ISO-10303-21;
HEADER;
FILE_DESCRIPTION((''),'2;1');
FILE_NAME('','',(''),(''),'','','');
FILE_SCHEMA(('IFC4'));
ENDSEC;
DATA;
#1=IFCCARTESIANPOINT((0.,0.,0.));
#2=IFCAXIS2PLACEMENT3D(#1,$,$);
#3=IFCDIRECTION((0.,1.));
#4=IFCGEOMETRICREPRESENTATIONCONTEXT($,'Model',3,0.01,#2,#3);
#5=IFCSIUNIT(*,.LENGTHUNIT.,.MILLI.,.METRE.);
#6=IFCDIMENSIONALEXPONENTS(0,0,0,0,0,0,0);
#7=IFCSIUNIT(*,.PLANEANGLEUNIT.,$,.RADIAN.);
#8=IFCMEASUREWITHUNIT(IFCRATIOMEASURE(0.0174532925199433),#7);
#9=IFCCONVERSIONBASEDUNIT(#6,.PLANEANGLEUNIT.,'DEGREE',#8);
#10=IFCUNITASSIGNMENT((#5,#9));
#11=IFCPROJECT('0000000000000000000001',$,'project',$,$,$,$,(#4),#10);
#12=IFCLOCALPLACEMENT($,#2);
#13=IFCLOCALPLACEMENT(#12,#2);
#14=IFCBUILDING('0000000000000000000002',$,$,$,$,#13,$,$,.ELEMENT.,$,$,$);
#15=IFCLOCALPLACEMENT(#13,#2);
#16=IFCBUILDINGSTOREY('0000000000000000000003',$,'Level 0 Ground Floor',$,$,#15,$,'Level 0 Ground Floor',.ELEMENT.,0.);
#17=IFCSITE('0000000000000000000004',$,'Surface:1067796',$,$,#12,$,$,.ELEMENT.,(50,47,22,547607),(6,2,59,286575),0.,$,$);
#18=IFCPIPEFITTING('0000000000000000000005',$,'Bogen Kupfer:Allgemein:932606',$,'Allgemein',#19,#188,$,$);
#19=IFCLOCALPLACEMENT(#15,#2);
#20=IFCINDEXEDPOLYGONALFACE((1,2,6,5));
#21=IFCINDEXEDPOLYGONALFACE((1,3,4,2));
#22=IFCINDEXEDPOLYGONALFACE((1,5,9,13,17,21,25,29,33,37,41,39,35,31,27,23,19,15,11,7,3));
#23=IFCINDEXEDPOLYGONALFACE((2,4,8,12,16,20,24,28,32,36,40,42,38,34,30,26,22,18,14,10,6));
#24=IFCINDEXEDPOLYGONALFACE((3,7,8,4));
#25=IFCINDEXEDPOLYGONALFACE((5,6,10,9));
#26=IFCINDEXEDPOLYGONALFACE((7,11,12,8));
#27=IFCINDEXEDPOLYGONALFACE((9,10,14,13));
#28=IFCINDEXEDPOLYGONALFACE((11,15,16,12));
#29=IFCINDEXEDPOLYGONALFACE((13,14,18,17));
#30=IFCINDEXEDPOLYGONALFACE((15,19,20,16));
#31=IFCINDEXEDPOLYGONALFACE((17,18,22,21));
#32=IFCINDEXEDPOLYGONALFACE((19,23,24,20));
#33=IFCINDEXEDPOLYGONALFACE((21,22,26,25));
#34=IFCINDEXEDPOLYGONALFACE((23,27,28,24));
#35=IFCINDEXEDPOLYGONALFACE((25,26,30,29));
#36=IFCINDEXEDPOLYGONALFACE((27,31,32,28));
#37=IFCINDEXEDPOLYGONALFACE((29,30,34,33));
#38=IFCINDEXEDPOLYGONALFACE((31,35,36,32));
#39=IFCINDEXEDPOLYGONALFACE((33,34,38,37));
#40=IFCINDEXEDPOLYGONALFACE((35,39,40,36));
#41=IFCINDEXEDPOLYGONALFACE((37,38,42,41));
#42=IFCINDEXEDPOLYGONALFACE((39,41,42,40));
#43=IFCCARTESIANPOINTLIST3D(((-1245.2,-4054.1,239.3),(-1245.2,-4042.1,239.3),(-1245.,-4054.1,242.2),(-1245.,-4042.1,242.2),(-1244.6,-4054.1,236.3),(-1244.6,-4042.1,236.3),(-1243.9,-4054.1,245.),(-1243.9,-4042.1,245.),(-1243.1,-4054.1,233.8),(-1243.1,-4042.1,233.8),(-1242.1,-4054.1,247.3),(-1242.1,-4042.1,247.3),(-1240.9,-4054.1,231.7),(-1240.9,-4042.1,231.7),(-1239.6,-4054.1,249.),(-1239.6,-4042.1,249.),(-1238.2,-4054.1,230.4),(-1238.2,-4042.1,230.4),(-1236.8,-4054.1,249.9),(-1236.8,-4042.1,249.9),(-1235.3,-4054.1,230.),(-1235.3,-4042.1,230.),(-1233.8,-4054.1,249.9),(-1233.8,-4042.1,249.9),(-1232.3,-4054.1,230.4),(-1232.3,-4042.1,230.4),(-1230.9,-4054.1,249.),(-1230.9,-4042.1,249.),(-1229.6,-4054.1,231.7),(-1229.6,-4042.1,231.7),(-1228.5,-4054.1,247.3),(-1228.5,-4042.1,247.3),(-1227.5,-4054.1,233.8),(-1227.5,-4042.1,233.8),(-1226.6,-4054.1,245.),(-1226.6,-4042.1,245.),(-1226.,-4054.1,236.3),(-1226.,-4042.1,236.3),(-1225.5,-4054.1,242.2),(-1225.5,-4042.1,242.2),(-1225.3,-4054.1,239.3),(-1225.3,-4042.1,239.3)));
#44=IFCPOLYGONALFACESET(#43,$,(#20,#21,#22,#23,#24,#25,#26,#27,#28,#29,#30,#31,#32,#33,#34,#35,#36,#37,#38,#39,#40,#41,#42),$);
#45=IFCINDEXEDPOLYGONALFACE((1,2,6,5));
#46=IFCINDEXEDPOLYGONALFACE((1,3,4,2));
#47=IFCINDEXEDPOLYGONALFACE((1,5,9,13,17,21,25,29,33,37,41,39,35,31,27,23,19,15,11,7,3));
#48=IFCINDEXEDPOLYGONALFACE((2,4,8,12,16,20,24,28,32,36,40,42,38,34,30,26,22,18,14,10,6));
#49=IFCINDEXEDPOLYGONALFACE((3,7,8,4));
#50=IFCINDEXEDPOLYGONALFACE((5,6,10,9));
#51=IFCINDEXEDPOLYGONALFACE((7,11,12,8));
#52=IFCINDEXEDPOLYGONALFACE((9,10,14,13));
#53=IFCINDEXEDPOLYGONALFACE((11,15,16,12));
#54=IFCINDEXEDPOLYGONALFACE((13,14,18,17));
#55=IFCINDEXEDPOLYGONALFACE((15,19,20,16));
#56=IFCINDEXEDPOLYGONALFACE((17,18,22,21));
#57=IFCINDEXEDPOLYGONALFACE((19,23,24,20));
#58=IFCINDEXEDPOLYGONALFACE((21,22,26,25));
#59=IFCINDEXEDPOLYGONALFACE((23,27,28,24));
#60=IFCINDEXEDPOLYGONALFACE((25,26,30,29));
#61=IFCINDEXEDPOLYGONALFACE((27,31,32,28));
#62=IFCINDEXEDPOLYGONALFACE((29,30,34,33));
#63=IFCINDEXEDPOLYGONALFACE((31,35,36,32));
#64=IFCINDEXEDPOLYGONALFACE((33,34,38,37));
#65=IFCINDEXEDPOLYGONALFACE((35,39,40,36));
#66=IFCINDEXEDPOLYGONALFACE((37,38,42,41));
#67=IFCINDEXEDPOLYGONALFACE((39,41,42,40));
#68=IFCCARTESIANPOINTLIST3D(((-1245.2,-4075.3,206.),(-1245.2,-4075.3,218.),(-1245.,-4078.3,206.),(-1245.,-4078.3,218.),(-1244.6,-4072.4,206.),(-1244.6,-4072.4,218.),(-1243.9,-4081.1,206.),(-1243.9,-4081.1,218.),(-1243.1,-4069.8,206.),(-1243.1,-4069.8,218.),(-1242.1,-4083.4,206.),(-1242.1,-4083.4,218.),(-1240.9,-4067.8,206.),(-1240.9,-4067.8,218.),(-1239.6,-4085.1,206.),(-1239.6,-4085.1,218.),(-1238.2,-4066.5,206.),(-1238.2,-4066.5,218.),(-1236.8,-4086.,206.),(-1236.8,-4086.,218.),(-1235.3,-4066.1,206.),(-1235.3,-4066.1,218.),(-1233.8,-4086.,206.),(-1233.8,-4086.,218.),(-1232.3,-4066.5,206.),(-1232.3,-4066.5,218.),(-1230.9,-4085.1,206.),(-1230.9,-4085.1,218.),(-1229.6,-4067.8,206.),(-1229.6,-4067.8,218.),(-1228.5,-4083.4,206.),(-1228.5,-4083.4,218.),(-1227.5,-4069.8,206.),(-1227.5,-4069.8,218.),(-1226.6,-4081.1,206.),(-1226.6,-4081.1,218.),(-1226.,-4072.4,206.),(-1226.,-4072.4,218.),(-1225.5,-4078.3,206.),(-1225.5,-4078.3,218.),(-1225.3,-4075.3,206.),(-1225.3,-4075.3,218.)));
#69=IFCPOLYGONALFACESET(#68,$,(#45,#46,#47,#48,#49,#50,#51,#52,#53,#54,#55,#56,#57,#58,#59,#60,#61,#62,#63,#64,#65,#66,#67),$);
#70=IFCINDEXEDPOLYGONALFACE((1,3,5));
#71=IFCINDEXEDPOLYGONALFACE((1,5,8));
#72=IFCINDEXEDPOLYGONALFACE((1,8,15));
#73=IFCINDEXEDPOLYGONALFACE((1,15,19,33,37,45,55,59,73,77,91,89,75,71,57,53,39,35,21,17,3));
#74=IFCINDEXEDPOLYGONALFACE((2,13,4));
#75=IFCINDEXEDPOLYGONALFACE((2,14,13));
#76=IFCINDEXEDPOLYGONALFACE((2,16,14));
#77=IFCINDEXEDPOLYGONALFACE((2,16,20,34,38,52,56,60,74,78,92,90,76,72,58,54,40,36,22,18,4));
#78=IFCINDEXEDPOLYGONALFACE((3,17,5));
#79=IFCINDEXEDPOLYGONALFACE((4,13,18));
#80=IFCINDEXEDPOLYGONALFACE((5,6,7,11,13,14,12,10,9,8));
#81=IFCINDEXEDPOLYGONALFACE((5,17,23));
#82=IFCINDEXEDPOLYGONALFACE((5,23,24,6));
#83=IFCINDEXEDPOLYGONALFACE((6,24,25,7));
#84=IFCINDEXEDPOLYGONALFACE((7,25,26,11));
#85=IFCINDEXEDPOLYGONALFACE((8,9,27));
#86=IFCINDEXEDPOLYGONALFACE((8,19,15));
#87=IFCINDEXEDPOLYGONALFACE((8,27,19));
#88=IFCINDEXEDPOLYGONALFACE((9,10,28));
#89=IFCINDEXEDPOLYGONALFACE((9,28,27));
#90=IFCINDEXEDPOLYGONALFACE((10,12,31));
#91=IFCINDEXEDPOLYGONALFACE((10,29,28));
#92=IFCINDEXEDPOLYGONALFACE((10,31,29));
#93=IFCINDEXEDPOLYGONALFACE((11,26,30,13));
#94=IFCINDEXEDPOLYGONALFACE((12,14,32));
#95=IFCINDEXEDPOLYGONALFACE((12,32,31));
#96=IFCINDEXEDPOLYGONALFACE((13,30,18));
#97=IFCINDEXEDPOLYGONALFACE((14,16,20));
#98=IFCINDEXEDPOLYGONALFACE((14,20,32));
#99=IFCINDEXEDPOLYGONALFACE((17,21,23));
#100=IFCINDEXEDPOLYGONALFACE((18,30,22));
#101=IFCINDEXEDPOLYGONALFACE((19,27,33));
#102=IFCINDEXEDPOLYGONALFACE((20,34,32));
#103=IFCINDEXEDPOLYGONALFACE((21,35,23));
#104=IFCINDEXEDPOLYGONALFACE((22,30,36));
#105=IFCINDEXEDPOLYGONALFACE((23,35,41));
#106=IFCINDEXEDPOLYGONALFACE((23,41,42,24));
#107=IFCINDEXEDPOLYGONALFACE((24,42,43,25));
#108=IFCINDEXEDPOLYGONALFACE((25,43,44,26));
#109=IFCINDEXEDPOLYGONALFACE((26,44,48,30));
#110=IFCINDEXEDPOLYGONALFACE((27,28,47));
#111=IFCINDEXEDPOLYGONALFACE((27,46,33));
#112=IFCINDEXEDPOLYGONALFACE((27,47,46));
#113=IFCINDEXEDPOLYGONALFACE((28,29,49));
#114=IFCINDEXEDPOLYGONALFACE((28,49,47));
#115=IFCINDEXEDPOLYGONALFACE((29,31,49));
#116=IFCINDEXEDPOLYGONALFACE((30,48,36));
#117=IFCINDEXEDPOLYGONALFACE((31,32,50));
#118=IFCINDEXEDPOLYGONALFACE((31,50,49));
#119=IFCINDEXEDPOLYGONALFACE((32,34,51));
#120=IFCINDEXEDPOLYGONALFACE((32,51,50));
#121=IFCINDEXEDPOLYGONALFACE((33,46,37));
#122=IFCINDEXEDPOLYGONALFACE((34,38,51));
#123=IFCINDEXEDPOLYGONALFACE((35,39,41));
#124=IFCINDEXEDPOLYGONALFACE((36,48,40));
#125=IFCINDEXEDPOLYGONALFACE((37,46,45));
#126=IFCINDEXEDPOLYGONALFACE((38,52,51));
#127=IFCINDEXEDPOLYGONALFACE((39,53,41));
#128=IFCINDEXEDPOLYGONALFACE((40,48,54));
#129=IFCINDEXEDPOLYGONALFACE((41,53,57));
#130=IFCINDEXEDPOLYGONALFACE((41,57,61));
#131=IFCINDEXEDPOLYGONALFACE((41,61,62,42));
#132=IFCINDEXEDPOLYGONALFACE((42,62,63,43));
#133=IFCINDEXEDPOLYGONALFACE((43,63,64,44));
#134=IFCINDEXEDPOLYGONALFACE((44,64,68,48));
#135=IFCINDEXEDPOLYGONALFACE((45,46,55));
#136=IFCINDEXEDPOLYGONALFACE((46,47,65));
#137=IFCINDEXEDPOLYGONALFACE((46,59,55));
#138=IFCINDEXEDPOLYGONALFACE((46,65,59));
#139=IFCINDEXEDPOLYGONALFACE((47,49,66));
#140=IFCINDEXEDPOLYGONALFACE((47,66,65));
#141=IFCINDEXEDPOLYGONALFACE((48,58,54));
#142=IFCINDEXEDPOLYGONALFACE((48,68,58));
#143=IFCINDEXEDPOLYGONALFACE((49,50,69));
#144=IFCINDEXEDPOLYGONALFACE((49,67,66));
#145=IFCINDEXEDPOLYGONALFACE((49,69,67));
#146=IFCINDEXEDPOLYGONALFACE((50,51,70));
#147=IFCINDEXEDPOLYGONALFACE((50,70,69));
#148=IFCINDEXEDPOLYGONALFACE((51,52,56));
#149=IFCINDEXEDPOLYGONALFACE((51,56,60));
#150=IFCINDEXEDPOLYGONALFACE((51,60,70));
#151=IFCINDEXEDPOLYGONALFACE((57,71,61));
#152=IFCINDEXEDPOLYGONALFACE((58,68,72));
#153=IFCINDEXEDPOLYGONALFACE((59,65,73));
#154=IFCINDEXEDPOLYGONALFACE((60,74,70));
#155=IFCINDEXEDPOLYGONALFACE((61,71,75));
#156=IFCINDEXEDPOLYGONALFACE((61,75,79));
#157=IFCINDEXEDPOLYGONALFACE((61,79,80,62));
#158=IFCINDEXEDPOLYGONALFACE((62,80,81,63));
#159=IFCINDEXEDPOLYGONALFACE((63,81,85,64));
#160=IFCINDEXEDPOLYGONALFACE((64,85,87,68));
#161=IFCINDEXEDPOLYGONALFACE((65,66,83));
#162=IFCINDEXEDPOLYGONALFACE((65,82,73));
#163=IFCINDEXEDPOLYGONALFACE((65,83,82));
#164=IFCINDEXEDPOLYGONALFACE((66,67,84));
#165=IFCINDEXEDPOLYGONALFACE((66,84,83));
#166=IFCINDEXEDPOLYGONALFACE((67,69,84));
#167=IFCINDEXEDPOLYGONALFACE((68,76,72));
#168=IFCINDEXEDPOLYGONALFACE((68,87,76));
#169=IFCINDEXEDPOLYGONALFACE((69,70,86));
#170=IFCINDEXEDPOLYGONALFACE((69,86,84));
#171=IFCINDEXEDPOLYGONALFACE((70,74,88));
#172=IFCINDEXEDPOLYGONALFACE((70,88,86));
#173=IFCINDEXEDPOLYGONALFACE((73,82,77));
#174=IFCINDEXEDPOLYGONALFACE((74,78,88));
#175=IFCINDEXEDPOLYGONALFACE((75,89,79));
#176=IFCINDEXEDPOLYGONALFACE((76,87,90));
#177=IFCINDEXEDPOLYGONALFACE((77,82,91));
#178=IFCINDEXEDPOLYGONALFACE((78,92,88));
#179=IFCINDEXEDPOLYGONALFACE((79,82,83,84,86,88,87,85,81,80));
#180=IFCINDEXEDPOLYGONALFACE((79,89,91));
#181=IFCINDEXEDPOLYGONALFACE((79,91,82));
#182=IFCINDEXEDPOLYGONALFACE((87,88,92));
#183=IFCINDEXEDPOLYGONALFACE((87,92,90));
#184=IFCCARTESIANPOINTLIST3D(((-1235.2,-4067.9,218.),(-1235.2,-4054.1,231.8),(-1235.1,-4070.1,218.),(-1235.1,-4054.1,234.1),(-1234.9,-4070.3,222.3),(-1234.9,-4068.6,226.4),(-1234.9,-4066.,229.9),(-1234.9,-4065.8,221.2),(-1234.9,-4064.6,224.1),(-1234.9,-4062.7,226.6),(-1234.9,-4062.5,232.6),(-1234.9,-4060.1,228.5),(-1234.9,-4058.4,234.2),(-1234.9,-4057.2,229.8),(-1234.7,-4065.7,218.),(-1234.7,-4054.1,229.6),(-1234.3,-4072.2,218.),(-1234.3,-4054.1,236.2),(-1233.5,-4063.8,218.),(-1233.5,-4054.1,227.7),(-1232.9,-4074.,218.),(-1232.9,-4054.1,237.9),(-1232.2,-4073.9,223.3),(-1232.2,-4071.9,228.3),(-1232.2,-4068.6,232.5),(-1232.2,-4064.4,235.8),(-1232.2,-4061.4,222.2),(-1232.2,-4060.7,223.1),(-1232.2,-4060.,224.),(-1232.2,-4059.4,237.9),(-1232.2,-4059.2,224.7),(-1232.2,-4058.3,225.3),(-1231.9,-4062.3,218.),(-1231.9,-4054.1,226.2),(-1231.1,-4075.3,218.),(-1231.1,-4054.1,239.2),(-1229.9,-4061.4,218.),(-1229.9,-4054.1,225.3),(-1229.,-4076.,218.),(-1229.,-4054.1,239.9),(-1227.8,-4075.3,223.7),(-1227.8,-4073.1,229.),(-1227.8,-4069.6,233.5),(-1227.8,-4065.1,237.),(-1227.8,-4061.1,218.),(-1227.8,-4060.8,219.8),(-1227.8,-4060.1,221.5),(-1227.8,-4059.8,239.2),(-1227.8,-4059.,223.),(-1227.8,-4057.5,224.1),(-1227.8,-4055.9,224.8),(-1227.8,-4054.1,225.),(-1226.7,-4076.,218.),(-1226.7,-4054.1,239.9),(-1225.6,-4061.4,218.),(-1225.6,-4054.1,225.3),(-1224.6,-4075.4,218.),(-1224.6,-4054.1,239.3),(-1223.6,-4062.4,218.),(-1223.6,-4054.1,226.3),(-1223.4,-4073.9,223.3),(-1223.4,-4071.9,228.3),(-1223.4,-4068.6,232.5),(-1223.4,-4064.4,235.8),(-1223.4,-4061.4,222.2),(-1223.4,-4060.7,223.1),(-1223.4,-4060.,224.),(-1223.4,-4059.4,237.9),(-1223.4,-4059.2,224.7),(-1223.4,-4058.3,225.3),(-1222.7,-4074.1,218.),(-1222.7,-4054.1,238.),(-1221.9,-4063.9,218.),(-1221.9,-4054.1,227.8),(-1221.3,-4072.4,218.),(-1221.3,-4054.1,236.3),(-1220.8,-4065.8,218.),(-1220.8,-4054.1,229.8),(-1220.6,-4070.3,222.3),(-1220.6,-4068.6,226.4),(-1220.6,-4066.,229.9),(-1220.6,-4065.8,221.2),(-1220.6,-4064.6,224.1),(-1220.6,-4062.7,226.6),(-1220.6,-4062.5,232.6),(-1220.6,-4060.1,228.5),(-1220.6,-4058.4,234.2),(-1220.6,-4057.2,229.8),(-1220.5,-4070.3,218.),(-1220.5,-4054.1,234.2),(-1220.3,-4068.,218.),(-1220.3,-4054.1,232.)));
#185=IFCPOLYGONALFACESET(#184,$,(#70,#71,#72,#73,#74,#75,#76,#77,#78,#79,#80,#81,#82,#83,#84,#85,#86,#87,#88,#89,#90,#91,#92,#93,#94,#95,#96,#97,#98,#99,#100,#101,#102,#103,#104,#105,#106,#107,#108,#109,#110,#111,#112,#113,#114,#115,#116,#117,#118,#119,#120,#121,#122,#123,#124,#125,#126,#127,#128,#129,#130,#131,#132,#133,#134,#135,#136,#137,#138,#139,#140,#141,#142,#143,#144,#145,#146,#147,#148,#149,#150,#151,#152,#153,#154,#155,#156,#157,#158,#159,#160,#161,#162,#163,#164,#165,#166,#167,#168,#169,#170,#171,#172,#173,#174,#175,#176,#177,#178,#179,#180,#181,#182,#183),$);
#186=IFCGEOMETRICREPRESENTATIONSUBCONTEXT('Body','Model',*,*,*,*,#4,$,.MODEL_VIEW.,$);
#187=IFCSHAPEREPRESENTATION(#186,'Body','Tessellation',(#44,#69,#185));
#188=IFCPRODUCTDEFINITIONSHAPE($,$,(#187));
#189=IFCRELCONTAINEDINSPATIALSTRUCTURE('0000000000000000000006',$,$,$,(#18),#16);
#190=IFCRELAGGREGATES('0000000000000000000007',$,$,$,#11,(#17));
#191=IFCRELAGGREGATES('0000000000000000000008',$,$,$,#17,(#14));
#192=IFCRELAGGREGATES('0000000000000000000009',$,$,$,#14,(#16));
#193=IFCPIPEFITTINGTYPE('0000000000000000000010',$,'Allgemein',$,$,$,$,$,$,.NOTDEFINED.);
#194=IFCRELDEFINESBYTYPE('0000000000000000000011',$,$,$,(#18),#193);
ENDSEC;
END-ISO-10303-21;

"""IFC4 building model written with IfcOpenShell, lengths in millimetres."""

from ifc_helpers import new_model, entity, si_unit, converted_unit, direction, frame, frame_2d, origin, place, context, subcontext, project, spatial, circle, extrude, source, transform, mapped, type_object, type_shapes, element, save


model = new_model("IFC4")

# Units and contexts
model_context = context("Model", 3, precision=0.01, world=origin(), true_north=direction((0.0, 1.0)))
body_context = subcontext(model_context, "Body", "Model", "MODEL_VIEW")
ifc_project = project(units=[si_unit("LENGTHUNIT", "METRE", prefix="MILLI"), converted_unit("PLANEANGLEUNIT", "DEGREE", entity("IfcRatioMeasure", 0.0174532925199433), si_unit("PLANEANGLEUNIT", "RADIAN"), dimensions=[0, 0, 0, 0, 0, 0, 0])], contexts=[model_context])

# Site, building, storey
site_placement = place(None, origin())
site = spatial("IfcSite", under=ifc_project, at=site_placement, Name="Surface:1067796", CompositionType="ELEMENT", RefLatitude=(50, 47, 22, 547607), RefLongitude=(6, 2, 59, 286575), RefElevation=0.0)
building_placement = place(site_placement, origin())
building = spatial("IfcBuilding", under=site, at=building_placement, CompositionType="ELEMENT")
storey_placement = place(building_placement, origin())
storey = spatial("IfcBuildingStorey", under=building, at=storey_placement, Name="Level 0 Ground Floor", LongName="Level 0 Ground Floor", CompositionType="ELEMENT", Elevation=0.0)

# Pipe fitting
pipe_fitting_type_1 = type_object("IfcPipeFittingType", Name="Allgemein", PredefinedType="NOTDEFINED")
ifc_direction = entity("IfcDirection", [0.0, 0.0, -1.0])
trimmed_curve = entity("IfcTrimmedCurve", entity("IfcCircle", entity("IfcAxis2Placement2D", entity("IfcCartesianPoint", [-14.5, 0.0]), entity("IfcDirection", [0.0, 1.0])), 14.5), [entity("IfcParameterValue", 270.0)], [entity("IfcParameterValue", 0.0)], True, "PARAMETER")
shared_shape_1 = source(origin(), body_context, "Body", "SolidModel", [
    extrude(circle(Radius=10.0, at=frame_2d((0.0, 0.0), x_axis=(1.0, 0.0))), frame((0.0, 22.0, 0.0), z_axis=(0.0, 1.0, 0.0), x_axis=(-1.0, 0.0, 0.0)), (0.0, 0.0, 1.0), 12.0),
    extrude(circle(Radius=10.0, at=frame_2d((0.0, 0.0), x_axis=(1.0, 0.0))), frame((-34.0, 0.0, 0.0), z_axis=(1.0, 0.0, 0.0), x_axis=(0.0, 1.0, 0.0)), (0.0, 0.0, 1.0), 12.0),
    entity("IfcSurfaceCurveSweptAreaSolid", entity("IfcCircleProfileDef", "AREA", None, entity("IfcAxis2Placement2D", entity("IfcCartesianPoint", [0.0, 7.5]), entity("IfcDirection", [1.0, 0.0])), 7.5), entity("IfcAxis2Placement3D", entity("IfcCartesianPoint", [-7.5, 22.0, 0.0]), ifc_direction, entity("IfcDirection", [1.0, 0.0, 0.0])), trimmed_curve, 0.0, 90.0, entity("IfcSurfaceOfLinearExtrusion", entity("IfcArbitraryOpenProfileDef", "CURVE", None, trimmed_curve), entity("IfcAxis2Placement3D", entity("IfcCartesianPoint", [0.0, 0.0, -304.8])), ifc_direction, 1.0)),
])
type_shapes(pipe_fitting_type_1, [shared_shape_1])
for number, where, z_axis, x_axis, name in (
    (1, (-1235.3, -4076.1, 240.0), (-1.0, 0.0, 0.0), (0.0, 0.0, 1.0), "Bogen Kupfer:Allgemein:932606"),
):
    element("IfcPipeFitting", number, at=place(storey_placement, frame(where, z_axis=z_axis, x_axis=x_axis)), inside=storey, type_object=pipe_fitting_type_1, Name=name, ObjectType="Allgemein", context=body_context, shape_type="MappedRepresentation", body=[
        mapped(shared_shape_1, transform((0.0, 0.0, 0.0), scale=1.0)),
    ])

save(model, "model.ifc")
